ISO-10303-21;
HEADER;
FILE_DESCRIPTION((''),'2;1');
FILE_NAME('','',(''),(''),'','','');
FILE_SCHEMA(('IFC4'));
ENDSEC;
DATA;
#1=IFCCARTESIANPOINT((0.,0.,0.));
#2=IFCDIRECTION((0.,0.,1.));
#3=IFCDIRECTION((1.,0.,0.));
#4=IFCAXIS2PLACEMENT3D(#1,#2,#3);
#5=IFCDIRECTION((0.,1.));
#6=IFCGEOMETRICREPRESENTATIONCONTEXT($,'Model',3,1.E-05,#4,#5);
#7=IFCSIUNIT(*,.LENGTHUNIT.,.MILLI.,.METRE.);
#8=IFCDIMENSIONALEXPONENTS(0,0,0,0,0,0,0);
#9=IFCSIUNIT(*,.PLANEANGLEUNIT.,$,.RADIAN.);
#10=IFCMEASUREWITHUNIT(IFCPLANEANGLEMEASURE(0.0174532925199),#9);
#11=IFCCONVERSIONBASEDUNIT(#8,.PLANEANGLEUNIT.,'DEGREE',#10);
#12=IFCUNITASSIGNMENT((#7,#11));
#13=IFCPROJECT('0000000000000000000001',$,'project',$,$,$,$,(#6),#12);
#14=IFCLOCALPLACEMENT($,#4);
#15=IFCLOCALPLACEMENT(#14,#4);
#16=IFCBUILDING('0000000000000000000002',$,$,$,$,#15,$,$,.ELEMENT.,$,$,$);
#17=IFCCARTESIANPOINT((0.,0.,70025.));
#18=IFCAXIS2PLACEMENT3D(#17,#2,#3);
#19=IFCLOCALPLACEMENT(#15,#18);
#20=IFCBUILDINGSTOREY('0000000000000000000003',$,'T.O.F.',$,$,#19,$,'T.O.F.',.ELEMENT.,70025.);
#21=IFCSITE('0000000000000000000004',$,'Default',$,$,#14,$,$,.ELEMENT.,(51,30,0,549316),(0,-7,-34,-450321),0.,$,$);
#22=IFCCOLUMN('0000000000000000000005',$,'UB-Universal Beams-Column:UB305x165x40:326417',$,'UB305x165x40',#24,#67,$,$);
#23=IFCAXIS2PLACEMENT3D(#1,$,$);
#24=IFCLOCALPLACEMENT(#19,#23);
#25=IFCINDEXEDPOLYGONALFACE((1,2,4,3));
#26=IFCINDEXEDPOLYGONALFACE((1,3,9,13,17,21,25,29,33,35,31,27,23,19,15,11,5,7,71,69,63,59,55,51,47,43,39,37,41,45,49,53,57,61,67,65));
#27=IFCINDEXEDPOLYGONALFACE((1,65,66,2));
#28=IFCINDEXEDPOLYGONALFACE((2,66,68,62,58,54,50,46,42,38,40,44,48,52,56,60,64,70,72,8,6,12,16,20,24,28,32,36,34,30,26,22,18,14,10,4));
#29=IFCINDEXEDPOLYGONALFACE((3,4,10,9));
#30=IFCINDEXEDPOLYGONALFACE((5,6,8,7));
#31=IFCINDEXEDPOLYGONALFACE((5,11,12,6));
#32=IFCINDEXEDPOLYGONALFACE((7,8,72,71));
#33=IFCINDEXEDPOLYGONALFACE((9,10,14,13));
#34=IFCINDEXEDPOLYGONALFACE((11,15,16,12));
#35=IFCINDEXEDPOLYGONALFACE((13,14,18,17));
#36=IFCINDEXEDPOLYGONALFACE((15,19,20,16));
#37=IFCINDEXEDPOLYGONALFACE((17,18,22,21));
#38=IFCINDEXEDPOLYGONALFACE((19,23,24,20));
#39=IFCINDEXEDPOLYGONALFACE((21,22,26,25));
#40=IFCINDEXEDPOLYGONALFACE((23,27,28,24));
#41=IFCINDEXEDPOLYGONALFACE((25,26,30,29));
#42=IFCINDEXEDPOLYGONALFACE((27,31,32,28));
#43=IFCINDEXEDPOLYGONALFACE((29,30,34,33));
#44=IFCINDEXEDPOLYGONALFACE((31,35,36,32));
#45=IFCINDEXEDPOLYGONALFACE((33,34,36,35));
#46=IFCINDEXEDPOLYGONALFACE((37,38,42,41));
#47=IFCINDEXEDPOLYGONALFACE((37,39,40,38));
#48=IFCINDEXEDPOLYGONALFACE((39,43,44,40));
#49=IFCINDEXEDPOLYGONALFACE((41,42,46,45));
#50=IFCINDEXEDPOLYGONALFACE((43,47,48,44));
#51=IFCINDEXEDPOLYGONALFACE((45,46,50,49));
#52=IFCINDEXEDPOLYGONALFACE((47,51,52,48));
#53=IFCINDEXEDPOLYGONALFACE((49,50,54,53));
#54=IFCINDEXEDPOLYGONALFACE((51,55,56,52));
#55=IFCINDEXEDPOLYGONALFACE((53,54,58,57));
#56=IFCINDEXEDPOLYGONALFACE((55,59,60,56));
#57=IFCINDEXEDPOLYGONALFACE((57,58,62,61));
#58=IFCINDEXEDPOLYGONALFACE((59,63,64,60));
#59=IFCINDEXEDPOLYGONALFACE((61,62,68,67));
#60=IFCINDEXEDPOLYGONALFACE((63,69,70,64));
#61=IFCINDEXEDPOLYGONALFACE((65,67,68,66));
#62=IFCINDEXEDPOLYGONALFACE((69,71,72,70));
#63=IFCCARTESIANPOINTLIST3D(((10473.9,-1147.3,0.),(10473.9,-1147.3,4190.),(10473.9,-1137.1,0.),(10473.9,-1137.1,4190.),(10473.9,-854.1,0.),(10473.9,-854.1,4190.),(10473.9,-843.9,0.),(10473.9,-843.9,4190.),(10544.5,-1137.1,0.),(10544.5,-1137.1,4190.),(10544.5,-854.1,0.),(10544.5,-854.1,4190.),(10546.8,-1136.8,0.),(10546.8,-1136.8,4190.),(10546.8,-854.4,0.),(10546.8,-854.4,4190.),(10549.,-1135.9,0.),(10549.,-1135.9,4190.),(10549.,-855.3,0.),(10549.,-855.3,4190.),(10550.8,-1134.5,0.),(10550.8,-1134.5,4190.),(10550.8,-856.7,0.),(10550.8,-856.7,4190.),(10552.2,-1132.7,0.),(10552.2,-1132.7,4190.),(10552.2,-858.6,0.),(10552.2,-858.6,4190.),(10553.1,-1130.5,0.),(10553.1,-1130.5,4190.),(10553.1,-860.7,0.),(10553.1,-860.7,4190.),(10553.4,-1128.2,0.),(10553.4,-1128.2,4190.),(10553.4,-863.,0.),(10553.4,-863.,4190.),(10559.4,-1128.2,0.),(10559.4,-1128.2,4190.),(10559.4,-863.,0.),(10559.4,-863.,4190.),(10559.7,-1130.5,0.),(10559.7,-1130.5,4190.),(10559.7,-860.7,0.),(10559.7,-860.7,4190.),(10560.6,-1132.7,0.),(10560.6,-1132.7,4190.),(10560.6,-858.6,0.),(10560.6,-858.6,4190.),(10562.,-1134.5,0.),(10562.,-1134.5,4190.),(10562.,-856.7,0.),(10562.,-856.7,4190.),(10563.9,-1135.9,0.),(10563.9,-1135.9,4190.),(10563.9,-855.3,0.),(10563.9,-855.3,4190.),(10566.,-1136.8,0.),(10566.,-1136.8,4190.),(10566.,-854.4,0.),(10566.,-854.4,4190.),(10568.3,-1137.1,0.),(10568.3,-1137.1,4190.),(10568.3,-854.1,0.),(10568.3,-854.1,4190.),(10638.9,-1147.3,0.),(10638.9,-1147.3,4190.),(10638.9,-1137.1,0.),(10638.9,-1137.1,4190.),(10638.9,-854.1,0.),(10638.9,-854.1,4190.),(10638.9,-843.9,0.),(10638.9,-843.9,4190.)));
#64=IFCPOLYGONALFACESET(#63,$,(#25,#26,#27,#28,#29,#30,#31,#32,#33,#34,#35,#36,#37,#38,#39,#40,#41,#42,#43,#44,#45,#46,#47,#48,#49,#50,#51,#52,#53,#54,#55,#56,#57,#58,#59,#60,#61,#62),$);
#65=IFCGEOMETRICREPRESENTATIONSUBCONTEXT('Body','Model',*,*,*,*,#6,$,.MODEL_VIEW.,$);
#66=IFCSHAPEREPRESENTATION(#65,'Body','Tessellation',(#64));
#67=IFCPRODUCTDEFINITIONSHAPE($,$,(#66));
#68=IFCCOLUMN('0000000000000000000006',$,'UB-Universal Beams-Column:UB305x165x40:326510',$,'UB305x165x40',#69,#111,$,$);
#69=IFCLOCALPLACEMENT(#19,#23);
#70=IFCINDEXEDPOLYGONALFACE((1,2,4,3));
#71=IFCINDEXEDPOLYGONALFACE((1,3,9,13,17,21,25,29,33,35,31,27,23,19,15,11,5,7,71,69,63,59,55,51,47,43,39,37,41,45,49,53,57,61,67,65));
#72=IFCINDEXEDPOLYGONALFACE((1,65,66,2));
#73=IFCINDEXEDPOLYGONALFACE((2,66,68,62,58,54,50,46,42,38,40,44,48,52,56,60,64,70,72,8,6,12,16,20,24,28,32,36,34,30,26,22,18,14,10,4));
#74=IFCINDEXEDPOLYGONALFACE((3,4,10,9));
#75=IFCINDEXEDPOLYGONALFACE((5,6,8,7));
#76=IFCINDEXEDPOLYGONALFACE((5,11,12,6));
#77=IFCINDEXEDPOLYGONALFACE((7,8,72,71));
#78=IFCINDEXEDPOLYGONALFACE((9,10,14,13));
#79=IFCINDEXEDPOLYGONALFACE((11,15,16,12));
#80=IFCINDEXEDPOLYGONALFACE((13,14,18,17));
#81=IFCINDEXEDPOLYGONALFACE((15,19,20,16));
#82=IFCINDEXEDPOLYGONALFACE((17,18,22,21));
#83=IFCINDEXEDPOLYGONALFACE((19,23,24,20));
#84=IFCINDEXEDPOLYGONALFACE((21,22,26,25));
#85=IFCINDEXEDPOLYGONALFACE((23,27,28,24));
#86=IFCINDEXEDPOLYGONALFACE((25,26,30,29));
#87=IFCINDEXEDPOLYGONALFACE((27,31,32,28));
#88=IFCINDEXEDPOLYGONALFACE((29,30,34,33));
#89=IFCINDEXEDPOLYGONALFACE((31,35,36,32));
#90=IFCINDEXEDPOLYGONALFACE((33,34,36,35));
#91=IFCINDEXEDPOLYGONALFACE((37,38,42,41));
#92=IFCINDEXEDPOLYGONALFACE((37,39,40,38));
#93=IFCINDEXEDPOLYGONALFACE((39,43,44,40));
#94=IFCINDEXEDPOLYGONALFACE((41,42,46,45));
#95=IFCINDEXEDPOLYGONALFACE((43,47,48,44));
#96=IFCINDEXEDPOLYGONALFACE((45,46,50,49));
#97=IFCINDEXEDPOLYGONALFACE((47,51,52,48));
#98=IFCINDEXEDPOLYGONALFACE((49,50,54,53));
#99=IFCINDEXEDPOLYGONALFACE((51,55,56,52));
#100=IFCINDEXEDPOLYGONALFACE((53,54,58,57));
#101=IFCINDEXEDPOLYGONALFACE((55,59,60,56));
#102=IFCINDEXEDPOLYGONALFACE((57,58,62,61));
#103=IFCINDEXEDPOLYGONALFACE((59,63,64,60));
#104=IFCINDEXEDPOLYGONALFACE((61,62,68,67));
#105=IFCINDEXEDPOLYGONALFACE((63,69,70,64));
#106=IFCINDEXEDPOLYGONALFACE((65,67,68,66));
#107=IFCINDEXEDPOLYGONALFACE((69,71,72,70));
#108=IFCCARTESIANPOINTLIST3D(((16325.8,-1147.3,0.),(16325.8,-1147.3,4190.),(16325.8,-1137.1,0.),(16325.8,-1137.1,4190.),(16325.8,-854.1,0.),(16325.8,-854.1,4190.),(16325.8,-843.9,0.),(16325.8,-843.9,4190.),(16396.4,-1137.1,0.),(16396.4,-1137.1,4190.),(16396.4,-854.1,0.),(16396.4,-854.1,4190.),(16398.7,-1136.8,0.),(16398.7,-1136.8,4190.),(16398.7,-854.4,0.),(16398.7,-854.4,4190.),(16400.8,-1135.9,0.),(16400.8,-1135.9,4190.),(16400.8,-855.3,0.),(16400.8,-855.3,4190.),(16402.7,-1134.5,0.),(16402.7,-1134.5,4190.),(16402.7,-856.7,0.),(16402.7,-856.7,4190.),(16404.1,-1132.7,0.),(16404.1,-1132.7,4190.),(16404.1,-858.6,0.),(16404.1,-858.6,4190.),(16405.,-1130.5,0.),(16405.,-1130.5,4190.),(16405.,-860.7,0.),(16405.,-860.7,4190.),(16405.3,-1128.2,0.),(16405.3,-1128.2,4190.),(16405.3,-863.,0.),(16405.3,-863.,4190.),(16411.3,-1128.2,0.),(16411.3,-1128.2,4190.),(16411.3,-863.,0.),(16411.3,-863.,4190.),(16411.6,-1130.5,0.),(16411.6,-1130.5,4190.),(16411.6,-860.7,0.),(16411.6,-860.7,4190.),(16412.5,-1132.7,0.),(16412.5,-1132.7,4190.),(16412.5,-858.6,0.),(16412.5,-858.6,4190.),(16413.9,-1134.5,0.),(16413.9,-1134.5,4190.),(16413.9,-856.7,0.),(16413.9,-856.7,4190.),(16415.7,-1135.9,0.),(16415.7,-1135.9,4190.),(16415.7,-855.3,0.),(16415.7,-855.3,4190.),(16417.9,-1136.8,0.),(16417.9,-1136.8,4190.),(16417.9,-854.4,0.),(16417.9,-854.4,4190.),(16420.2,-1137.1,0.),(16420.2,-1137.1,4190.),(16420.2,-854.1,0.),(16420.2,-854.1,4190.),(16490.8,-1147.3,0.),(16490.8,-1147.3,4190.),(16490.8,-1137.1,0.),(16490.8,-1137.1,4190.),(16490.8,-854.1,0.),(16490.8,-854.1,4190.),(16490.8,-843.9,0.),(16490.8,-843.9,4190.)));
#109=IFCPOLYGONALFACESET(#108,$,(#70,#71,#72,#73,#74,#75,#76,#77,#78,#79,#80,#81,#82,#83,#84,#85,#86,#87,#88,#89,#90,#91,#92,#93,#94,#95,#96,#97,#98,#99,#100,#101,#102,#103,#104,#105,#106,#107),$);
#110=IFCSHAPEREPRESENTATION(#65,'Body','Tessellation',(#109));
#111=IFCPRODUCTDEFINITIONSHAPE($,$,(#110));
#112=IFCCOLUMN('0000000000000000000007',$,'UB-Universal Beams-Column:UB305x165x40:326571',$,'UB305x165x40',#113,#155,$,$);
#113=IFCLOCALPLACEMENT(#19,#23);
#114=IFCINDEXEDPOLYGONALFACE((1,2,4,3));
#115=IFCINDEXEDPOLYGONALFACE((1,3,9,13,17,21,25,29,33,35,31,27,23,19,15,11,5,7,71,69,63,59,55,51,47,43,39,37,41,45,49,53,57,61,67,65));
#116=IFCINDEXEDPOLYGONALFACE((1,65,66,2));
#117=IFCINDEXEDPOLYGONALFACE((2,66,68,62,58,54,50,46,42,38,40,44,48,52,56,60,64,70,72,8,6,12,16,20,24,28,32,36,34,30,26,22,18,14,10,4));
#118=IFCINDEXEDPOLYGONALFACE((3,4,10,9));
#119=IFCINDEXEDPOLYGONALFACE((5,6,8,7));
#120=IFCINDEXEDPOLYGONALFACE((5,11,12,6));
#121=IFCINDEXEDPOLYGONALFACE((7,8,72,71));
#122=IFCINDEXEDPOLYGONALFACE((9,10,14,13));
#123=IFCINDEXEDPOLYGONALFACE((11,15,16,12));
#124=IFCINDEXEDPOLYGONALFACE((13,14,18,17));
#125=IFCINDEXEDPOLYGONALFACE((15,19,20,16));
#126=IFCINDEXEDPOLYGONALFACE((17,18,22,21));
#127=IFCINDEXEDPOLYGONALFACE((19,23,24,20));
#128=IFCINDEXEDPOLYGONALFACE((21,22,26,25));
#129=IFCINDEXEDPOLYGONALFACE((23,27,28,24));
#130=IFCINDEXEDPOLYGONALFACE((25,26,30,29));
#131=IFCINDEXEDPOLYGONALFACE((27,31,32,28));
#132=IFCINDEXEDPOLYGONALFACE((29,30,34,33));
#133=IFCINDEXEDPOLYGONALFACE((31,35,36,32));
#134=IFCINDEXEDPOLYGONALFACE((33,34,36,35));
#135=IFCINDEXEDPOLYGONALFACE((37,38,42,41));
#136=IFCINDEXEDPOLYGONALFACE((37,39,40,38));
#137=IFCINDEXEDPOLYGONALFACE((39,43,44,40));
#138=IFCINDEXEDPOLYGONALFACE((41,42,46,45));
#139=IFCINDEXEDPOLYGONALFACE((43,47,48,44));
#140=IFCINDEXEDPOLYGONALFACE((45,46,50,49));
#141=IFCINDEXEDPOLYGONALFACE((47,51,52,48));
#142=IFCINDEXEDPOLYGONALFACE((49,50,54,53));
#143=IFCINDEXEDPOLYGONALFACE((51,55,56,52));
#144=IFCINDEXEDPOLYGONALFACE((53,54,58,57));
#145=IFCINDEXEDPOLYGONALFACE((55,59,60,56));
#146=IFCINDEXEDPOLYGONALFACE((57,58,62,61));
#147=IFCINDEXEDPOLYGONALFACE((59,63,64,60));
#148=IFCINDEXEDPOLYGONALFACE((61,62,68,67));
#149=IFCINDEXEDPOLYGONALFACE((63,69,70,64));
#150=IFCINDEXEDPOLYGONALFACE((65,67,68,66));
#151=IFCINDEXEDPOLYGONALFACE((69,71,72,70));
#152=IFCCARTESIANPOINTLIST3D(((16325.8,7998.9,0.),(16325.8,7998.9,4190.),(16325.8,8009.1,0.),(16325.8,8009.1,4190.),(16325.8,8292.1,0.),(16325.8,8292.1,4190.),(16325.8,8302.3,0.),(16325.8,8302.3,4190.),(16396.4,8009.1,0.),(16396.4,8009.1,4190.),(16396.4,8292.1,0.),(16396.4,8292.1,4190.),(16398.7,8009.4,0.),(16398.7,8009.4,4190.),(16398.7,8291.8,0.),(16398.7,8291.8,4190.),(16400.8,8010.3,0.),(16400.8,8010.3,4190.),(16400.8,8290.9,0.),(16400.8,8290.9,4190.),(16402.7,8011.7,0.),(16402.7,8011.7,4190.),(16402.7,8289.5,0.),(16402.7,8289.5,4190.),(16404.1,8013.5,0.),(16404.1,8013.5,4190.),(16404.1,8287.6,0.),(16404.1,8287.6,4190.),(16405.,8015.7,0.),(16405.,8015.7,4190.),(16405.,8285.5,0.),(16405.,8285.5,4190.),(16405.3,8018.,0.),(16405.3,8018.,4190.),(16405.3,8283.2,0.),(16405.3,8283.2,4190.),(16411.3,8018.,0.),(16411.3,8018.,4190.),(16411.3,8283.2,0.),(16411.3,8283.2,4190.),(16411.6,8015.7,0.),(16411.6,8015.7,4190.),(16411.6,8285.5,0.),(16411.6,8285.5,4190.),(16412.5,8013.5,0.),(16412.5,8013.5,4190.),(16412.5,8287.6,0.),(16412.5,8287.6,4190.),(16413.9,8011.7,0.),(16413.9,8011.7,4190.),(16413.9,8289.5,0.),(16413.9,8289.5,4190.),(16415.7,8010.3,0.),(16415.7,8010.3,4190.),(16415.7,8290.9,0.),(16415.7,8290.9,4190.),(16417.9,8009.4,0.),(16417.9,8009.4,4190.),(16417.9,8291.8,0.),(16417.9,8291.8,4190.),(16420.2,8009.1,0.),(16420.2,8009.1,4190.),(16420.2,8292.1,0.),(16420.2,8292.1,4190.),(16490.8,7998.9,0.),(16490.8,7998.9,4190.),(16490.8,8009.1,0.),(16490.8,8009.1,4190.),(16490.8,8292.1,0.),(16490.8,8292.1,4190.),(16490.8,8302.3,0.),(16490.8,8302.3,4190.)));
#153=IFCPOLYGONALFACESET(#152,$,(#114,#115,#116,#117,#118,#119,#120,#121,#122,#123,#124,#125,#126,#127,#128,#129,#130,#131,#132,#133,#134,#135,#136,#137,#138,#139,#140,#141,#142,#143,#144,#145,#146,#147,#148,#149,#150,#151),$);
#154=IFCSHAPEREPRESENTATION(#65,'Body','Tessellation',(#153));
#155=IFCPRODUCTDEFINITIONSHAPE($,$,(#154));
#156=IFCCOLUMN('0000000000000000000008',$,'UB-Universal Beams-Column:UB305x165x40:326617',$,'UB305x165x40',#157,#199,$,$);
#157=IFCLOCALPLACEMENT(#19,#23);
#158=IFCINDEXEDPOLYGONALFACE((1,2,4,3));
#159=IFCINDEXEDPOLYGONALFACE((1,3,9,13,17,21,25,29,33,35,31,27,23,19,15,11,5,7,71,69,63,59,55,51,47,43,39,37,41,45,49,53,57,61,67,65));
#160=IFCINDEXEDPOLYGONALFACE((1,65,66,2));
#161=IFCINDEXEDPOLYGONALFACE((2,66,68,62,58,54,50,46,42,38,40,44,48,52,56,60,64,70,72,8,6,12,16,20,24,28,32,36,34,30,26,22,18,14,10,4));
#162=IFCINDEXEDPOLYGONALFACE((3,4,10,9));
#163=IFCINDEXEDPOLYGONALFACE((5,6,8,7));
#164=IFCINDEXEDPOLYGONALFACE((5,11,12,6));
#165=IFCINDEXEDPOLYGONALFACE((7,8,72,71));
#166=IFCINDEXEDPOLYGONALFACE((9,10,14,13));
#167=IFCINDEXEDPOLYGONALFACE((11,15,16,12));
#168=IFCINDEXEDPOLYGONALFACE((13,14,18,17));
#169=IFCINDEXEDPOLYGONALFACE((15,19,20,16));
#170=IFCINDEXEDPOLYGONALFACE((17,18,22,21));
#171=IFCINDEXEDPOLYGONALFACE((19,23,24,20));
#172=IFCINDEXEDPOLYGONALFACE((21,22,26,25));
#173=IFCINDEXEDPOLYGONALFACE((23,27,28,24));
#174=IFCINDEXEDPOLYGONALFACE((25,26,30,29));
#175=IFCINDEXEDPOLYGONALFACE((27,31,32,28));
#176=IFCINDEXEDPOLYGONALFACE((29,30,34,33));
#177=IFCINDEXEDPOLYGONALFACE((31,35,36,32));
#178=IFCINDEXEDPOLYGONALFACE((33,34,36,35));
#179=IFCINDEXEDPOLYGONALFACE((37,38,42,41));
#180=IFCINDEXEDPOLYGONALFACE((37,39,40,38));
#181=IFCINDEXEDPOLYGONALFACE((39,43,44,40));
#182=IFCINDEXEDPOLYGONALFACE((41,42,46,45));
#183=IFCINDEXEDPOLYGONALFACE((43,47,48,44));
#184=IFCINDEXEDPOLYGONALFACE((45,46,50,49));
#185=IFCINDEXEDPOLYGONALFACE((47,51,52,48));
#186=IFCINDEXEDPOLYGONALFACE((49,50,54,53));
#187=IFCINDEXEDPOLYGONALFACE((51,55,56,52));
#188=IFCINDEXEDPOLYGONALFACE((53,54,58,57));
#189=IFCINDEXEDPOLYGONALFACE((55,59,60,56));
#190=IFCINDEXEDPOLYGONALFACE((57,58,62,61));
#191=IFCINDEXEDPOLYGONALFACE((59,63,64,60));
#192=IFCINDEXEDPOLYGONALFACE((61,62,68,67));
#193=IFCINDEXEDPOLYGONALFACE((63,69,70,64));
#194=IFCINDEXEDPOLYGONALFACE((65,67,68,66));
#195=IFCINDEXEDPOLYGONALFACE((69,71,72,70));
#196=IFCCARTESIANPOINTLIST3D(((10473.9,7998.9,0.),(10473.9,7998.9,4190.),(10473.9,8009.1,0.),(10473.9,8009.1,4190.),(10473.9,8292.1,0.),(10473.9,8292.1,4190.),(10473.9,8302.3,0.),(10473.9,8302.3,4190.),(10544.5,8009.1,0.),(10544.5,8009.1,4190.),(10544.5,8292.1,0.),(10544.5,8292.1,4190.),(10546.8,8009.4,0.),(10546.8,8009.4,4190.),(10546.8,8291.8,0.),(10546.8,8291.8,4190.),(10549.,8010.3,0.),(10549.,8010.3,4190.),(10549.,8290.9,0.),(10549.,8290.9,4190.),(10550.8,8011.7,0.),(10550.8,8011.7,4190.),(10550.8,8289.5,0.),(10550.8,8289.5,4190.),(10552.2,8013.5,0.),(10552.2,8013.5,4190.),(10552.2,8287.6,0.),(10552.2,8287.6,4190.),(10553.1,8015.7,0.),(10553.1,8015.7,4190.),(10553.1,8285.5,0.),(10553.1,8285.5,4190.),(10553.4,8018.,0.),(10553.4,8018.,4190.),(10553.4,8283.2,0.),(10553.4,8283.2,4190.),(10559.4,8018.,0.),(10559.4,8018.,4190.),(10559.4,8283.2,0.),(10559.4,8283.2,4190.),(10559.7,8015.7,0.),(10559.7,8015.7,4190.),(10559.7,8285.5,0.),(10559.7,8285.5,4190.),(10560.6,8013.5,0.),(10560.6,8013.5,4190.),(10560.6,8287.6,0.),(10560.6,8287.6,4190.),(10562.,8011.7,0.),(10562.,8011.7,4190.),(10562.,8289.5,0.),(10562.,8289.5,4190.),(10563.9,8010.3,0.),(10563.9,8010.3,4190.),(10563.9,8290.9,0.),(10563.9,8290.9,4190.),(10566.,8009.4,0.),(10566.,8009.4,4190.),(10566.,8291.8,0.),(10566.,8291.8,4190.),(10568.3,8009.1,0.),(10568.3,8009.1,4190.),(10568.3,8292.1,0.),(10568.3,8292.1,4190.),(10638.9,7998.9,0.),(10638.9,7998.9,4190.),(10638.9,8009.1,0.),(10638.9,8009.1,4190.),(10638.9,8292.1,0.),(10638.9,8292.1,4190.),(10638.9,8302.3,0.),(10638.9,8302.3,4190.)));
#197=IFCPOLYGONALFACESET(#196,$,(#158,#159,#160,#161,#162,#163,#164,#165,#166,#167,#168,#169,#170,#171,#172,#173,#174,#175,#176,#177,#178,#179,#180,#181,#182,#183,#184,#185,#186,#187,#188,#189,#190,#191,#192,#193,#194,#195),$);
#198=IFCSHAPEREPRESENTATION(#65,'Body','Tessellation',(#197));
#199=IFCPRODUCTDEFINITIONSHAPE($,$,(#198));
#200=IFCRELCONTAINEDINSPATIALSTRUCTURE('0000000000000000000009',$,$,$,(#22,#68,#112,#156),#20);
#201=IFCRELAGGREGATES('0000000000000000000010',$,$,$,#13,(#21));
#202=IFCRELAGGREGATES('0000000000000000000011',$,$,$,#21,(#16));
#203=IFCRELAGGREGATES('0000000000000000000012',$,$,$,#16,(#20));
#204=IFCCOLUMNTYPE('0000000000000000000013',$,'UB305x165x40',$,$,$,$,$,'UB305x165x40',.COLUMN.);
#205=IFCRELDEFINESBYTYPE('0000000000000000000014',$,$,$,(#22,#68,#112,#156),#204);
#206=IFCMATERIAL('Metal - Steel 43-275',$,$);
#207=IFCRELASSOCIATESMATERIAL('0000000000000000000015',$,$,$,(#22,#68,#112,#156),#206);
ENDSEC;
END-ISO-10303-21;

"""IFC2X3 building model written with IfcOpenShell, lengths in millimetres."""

from ifc_helpers import new_model, entity, si_unit, converted_unit, point, direction, frame, frame_2d, origin_with_axes, place, context, subcontext, project, spatial, polyline, circle_curve, parameter, trimmed, segment, composite_curve, outline, extrude, material, type_object, element, save


model = new_model("IFC2X3")

# Units and contexts
model_context = context("Model", 3, precision=1e-05, world=origin_with_axes(), true_north=direction((0.0, 1.0)))
body_context = subcontext(model_context, "Body", "Model", "MODEL_VIEW")
ifc_project = project(units=[si_unit("LENGTHUNIT", "METRE", prefix="MILLI"), converted_unit("PLANEANGLEUNIT", "DEGREE", entity("IfcPlaneAngleMeasure", 0.0174532925199), si_unit("PLANEANGLEUNIT", "RADIAN"), dimensions=[0, 0, 0, 0, 0, 0, 0])], contexts=[model_context])

# Site, building, storey
site_placement = place(None, origin_with_axes())
site = spatial("IfcSite", under=ifc_project, at=site_placement, Name="Default", CompositionType="ELEMENT", RefLatitude=(51, 30, 0, 549316), RefLongitude=(0, -7, -34, -450321), RefElevation=0.0)
building_placement = place(site_placement, origin_with_axes())
building = spatial("IfcBuilding", under=site, at=building_placement, CompositionType="ELEMENT")
storey_placement = place(building_placement, frame((0.0, 0.0, 70025.0), z_axis=(0.0, 0.0, 1.0), x_axis=(1.0, 0.0, 0.0)))
storey = spatial("IfcBuildingStorey", under=building, at=storey_placement, Name="T.O.F.", LongName="T.O.F.", CompositionType="ELEMENT", Elevation=70025.0)

# Columns
ifc_material_1 = material(Name="Metal - Steel 43-275")
column_type_1 = type_object("IfcColumnType", Name="UB305x165x40", ElementType="UB305x165x40", PredefinedType="COLUMN")
for number, where, z_axis, x_axis, name in (
    (1, (10556.4, -995.6, 0.0), (0.0, 0.0, 1.0), (0.0, -1.0, 0.0), "UB-Universal Beams-Column:UB305x165x40:326417"),
    (2, (16408.3, -995.6, 0.0), (0.0, 0.0, 1.0), (0.0, -1.0, 0.0), "UB-Universal Beams-Column:UB305x165x40:326510"),
    (3, (16408.3, 8150.6, 0.0), (0.0, 0.0, 1.0), (0.0, -1.0, 0.0), "UB-Universal Beams-Column:UB305x165x40:326571"),
    (4, (10556.4, 8150.6, 0.0), (0.0, 0.0, 1.0), (0.0, -1.0, 0.0), "UB-Universal Beams-Column:UB305x165x40:326617"),
):
    element("IfcColumn", number, at=place(storey_placement, frame(where, z_axis=z_axis, x_axis=x_axis)), inside=storey, type_object=column_type_1, material=ifc_material_1, Name=name, ObjectType="UB305x165x40", context=body_context, shape_type="SweptSolid", body=[
        extrude(outline(composite_curve([segment(polyline([(141.5, -82.5), (151.7, -82.5), (151.7, 82.5), (141.5, 82.5), (141.5, 11.9)]), True, "CONTINUOUS"), segment(trimmed(circle_curve(frame_2d((132.6, 11.9), x_axis=(0.0, -1.0)), 8.9), [point((141.5, 11.9)), parameter(90.0)], [point((132.6, 3.0)), parameter(0.0)], False, "CARTESIAN"), True, "CONTINUOUS"), segment(polyline([(132.6, 3.0), (-132.6, 3.0)]), True, "CONTINUOUS"), segment(trimmed(circle_curve(frame_2d((-132.6, 11.9), x_axis=(-1.0, 0.0)), 8.9), [point((-132.6, 3.0)), parameter(90.0)], [point((-141.5, 11.9)), parameter(0.0)], False, "CARTESIAN"), True, "CONTINUOUS"), segment(polyline([(-141.5, 11.9), (-141.5, 82.5), (-151.7, 82.5), (-151.7, -82.5), (-141.5, -82.5), (-141.5, -11.9)]), True, "CONTINUOUS"), segment(trimmed(circle_curve(frame_2d((-132.6, -11.9), x_axis=(0.0, 1.0)), 8.9), [point((-141.5, -11.9)), parameter(90.0)], [point((-132.6, -3.0)), parameter(0.0)], False, "CARTESIAN"), True, "CONTINUOUS"), segment(polyline([(-132.6, -3.0), (132.6, -3.0)]), True, "CONTINUOUS"), segment(trimmed(circle_curve(frame_2d((132.6, -11.9), x_axis=(1.0, 0.0)), 8.9), [point((132.6, -3.0)), parameter(90.0)], [point((141.5, -11.9)), parameter(0.0)], False, "CARTESIAN"), True, "CONTINUOUS"), segment(polyline([(141.5, -11.9), (141.5, -82.5)]), True, "CONTINUOUS")], self_intersect=False)), origin_with_axes(), (0.0, 0.0, 1.0), 4190.0),
    ])

save(model, "model.ifc")
